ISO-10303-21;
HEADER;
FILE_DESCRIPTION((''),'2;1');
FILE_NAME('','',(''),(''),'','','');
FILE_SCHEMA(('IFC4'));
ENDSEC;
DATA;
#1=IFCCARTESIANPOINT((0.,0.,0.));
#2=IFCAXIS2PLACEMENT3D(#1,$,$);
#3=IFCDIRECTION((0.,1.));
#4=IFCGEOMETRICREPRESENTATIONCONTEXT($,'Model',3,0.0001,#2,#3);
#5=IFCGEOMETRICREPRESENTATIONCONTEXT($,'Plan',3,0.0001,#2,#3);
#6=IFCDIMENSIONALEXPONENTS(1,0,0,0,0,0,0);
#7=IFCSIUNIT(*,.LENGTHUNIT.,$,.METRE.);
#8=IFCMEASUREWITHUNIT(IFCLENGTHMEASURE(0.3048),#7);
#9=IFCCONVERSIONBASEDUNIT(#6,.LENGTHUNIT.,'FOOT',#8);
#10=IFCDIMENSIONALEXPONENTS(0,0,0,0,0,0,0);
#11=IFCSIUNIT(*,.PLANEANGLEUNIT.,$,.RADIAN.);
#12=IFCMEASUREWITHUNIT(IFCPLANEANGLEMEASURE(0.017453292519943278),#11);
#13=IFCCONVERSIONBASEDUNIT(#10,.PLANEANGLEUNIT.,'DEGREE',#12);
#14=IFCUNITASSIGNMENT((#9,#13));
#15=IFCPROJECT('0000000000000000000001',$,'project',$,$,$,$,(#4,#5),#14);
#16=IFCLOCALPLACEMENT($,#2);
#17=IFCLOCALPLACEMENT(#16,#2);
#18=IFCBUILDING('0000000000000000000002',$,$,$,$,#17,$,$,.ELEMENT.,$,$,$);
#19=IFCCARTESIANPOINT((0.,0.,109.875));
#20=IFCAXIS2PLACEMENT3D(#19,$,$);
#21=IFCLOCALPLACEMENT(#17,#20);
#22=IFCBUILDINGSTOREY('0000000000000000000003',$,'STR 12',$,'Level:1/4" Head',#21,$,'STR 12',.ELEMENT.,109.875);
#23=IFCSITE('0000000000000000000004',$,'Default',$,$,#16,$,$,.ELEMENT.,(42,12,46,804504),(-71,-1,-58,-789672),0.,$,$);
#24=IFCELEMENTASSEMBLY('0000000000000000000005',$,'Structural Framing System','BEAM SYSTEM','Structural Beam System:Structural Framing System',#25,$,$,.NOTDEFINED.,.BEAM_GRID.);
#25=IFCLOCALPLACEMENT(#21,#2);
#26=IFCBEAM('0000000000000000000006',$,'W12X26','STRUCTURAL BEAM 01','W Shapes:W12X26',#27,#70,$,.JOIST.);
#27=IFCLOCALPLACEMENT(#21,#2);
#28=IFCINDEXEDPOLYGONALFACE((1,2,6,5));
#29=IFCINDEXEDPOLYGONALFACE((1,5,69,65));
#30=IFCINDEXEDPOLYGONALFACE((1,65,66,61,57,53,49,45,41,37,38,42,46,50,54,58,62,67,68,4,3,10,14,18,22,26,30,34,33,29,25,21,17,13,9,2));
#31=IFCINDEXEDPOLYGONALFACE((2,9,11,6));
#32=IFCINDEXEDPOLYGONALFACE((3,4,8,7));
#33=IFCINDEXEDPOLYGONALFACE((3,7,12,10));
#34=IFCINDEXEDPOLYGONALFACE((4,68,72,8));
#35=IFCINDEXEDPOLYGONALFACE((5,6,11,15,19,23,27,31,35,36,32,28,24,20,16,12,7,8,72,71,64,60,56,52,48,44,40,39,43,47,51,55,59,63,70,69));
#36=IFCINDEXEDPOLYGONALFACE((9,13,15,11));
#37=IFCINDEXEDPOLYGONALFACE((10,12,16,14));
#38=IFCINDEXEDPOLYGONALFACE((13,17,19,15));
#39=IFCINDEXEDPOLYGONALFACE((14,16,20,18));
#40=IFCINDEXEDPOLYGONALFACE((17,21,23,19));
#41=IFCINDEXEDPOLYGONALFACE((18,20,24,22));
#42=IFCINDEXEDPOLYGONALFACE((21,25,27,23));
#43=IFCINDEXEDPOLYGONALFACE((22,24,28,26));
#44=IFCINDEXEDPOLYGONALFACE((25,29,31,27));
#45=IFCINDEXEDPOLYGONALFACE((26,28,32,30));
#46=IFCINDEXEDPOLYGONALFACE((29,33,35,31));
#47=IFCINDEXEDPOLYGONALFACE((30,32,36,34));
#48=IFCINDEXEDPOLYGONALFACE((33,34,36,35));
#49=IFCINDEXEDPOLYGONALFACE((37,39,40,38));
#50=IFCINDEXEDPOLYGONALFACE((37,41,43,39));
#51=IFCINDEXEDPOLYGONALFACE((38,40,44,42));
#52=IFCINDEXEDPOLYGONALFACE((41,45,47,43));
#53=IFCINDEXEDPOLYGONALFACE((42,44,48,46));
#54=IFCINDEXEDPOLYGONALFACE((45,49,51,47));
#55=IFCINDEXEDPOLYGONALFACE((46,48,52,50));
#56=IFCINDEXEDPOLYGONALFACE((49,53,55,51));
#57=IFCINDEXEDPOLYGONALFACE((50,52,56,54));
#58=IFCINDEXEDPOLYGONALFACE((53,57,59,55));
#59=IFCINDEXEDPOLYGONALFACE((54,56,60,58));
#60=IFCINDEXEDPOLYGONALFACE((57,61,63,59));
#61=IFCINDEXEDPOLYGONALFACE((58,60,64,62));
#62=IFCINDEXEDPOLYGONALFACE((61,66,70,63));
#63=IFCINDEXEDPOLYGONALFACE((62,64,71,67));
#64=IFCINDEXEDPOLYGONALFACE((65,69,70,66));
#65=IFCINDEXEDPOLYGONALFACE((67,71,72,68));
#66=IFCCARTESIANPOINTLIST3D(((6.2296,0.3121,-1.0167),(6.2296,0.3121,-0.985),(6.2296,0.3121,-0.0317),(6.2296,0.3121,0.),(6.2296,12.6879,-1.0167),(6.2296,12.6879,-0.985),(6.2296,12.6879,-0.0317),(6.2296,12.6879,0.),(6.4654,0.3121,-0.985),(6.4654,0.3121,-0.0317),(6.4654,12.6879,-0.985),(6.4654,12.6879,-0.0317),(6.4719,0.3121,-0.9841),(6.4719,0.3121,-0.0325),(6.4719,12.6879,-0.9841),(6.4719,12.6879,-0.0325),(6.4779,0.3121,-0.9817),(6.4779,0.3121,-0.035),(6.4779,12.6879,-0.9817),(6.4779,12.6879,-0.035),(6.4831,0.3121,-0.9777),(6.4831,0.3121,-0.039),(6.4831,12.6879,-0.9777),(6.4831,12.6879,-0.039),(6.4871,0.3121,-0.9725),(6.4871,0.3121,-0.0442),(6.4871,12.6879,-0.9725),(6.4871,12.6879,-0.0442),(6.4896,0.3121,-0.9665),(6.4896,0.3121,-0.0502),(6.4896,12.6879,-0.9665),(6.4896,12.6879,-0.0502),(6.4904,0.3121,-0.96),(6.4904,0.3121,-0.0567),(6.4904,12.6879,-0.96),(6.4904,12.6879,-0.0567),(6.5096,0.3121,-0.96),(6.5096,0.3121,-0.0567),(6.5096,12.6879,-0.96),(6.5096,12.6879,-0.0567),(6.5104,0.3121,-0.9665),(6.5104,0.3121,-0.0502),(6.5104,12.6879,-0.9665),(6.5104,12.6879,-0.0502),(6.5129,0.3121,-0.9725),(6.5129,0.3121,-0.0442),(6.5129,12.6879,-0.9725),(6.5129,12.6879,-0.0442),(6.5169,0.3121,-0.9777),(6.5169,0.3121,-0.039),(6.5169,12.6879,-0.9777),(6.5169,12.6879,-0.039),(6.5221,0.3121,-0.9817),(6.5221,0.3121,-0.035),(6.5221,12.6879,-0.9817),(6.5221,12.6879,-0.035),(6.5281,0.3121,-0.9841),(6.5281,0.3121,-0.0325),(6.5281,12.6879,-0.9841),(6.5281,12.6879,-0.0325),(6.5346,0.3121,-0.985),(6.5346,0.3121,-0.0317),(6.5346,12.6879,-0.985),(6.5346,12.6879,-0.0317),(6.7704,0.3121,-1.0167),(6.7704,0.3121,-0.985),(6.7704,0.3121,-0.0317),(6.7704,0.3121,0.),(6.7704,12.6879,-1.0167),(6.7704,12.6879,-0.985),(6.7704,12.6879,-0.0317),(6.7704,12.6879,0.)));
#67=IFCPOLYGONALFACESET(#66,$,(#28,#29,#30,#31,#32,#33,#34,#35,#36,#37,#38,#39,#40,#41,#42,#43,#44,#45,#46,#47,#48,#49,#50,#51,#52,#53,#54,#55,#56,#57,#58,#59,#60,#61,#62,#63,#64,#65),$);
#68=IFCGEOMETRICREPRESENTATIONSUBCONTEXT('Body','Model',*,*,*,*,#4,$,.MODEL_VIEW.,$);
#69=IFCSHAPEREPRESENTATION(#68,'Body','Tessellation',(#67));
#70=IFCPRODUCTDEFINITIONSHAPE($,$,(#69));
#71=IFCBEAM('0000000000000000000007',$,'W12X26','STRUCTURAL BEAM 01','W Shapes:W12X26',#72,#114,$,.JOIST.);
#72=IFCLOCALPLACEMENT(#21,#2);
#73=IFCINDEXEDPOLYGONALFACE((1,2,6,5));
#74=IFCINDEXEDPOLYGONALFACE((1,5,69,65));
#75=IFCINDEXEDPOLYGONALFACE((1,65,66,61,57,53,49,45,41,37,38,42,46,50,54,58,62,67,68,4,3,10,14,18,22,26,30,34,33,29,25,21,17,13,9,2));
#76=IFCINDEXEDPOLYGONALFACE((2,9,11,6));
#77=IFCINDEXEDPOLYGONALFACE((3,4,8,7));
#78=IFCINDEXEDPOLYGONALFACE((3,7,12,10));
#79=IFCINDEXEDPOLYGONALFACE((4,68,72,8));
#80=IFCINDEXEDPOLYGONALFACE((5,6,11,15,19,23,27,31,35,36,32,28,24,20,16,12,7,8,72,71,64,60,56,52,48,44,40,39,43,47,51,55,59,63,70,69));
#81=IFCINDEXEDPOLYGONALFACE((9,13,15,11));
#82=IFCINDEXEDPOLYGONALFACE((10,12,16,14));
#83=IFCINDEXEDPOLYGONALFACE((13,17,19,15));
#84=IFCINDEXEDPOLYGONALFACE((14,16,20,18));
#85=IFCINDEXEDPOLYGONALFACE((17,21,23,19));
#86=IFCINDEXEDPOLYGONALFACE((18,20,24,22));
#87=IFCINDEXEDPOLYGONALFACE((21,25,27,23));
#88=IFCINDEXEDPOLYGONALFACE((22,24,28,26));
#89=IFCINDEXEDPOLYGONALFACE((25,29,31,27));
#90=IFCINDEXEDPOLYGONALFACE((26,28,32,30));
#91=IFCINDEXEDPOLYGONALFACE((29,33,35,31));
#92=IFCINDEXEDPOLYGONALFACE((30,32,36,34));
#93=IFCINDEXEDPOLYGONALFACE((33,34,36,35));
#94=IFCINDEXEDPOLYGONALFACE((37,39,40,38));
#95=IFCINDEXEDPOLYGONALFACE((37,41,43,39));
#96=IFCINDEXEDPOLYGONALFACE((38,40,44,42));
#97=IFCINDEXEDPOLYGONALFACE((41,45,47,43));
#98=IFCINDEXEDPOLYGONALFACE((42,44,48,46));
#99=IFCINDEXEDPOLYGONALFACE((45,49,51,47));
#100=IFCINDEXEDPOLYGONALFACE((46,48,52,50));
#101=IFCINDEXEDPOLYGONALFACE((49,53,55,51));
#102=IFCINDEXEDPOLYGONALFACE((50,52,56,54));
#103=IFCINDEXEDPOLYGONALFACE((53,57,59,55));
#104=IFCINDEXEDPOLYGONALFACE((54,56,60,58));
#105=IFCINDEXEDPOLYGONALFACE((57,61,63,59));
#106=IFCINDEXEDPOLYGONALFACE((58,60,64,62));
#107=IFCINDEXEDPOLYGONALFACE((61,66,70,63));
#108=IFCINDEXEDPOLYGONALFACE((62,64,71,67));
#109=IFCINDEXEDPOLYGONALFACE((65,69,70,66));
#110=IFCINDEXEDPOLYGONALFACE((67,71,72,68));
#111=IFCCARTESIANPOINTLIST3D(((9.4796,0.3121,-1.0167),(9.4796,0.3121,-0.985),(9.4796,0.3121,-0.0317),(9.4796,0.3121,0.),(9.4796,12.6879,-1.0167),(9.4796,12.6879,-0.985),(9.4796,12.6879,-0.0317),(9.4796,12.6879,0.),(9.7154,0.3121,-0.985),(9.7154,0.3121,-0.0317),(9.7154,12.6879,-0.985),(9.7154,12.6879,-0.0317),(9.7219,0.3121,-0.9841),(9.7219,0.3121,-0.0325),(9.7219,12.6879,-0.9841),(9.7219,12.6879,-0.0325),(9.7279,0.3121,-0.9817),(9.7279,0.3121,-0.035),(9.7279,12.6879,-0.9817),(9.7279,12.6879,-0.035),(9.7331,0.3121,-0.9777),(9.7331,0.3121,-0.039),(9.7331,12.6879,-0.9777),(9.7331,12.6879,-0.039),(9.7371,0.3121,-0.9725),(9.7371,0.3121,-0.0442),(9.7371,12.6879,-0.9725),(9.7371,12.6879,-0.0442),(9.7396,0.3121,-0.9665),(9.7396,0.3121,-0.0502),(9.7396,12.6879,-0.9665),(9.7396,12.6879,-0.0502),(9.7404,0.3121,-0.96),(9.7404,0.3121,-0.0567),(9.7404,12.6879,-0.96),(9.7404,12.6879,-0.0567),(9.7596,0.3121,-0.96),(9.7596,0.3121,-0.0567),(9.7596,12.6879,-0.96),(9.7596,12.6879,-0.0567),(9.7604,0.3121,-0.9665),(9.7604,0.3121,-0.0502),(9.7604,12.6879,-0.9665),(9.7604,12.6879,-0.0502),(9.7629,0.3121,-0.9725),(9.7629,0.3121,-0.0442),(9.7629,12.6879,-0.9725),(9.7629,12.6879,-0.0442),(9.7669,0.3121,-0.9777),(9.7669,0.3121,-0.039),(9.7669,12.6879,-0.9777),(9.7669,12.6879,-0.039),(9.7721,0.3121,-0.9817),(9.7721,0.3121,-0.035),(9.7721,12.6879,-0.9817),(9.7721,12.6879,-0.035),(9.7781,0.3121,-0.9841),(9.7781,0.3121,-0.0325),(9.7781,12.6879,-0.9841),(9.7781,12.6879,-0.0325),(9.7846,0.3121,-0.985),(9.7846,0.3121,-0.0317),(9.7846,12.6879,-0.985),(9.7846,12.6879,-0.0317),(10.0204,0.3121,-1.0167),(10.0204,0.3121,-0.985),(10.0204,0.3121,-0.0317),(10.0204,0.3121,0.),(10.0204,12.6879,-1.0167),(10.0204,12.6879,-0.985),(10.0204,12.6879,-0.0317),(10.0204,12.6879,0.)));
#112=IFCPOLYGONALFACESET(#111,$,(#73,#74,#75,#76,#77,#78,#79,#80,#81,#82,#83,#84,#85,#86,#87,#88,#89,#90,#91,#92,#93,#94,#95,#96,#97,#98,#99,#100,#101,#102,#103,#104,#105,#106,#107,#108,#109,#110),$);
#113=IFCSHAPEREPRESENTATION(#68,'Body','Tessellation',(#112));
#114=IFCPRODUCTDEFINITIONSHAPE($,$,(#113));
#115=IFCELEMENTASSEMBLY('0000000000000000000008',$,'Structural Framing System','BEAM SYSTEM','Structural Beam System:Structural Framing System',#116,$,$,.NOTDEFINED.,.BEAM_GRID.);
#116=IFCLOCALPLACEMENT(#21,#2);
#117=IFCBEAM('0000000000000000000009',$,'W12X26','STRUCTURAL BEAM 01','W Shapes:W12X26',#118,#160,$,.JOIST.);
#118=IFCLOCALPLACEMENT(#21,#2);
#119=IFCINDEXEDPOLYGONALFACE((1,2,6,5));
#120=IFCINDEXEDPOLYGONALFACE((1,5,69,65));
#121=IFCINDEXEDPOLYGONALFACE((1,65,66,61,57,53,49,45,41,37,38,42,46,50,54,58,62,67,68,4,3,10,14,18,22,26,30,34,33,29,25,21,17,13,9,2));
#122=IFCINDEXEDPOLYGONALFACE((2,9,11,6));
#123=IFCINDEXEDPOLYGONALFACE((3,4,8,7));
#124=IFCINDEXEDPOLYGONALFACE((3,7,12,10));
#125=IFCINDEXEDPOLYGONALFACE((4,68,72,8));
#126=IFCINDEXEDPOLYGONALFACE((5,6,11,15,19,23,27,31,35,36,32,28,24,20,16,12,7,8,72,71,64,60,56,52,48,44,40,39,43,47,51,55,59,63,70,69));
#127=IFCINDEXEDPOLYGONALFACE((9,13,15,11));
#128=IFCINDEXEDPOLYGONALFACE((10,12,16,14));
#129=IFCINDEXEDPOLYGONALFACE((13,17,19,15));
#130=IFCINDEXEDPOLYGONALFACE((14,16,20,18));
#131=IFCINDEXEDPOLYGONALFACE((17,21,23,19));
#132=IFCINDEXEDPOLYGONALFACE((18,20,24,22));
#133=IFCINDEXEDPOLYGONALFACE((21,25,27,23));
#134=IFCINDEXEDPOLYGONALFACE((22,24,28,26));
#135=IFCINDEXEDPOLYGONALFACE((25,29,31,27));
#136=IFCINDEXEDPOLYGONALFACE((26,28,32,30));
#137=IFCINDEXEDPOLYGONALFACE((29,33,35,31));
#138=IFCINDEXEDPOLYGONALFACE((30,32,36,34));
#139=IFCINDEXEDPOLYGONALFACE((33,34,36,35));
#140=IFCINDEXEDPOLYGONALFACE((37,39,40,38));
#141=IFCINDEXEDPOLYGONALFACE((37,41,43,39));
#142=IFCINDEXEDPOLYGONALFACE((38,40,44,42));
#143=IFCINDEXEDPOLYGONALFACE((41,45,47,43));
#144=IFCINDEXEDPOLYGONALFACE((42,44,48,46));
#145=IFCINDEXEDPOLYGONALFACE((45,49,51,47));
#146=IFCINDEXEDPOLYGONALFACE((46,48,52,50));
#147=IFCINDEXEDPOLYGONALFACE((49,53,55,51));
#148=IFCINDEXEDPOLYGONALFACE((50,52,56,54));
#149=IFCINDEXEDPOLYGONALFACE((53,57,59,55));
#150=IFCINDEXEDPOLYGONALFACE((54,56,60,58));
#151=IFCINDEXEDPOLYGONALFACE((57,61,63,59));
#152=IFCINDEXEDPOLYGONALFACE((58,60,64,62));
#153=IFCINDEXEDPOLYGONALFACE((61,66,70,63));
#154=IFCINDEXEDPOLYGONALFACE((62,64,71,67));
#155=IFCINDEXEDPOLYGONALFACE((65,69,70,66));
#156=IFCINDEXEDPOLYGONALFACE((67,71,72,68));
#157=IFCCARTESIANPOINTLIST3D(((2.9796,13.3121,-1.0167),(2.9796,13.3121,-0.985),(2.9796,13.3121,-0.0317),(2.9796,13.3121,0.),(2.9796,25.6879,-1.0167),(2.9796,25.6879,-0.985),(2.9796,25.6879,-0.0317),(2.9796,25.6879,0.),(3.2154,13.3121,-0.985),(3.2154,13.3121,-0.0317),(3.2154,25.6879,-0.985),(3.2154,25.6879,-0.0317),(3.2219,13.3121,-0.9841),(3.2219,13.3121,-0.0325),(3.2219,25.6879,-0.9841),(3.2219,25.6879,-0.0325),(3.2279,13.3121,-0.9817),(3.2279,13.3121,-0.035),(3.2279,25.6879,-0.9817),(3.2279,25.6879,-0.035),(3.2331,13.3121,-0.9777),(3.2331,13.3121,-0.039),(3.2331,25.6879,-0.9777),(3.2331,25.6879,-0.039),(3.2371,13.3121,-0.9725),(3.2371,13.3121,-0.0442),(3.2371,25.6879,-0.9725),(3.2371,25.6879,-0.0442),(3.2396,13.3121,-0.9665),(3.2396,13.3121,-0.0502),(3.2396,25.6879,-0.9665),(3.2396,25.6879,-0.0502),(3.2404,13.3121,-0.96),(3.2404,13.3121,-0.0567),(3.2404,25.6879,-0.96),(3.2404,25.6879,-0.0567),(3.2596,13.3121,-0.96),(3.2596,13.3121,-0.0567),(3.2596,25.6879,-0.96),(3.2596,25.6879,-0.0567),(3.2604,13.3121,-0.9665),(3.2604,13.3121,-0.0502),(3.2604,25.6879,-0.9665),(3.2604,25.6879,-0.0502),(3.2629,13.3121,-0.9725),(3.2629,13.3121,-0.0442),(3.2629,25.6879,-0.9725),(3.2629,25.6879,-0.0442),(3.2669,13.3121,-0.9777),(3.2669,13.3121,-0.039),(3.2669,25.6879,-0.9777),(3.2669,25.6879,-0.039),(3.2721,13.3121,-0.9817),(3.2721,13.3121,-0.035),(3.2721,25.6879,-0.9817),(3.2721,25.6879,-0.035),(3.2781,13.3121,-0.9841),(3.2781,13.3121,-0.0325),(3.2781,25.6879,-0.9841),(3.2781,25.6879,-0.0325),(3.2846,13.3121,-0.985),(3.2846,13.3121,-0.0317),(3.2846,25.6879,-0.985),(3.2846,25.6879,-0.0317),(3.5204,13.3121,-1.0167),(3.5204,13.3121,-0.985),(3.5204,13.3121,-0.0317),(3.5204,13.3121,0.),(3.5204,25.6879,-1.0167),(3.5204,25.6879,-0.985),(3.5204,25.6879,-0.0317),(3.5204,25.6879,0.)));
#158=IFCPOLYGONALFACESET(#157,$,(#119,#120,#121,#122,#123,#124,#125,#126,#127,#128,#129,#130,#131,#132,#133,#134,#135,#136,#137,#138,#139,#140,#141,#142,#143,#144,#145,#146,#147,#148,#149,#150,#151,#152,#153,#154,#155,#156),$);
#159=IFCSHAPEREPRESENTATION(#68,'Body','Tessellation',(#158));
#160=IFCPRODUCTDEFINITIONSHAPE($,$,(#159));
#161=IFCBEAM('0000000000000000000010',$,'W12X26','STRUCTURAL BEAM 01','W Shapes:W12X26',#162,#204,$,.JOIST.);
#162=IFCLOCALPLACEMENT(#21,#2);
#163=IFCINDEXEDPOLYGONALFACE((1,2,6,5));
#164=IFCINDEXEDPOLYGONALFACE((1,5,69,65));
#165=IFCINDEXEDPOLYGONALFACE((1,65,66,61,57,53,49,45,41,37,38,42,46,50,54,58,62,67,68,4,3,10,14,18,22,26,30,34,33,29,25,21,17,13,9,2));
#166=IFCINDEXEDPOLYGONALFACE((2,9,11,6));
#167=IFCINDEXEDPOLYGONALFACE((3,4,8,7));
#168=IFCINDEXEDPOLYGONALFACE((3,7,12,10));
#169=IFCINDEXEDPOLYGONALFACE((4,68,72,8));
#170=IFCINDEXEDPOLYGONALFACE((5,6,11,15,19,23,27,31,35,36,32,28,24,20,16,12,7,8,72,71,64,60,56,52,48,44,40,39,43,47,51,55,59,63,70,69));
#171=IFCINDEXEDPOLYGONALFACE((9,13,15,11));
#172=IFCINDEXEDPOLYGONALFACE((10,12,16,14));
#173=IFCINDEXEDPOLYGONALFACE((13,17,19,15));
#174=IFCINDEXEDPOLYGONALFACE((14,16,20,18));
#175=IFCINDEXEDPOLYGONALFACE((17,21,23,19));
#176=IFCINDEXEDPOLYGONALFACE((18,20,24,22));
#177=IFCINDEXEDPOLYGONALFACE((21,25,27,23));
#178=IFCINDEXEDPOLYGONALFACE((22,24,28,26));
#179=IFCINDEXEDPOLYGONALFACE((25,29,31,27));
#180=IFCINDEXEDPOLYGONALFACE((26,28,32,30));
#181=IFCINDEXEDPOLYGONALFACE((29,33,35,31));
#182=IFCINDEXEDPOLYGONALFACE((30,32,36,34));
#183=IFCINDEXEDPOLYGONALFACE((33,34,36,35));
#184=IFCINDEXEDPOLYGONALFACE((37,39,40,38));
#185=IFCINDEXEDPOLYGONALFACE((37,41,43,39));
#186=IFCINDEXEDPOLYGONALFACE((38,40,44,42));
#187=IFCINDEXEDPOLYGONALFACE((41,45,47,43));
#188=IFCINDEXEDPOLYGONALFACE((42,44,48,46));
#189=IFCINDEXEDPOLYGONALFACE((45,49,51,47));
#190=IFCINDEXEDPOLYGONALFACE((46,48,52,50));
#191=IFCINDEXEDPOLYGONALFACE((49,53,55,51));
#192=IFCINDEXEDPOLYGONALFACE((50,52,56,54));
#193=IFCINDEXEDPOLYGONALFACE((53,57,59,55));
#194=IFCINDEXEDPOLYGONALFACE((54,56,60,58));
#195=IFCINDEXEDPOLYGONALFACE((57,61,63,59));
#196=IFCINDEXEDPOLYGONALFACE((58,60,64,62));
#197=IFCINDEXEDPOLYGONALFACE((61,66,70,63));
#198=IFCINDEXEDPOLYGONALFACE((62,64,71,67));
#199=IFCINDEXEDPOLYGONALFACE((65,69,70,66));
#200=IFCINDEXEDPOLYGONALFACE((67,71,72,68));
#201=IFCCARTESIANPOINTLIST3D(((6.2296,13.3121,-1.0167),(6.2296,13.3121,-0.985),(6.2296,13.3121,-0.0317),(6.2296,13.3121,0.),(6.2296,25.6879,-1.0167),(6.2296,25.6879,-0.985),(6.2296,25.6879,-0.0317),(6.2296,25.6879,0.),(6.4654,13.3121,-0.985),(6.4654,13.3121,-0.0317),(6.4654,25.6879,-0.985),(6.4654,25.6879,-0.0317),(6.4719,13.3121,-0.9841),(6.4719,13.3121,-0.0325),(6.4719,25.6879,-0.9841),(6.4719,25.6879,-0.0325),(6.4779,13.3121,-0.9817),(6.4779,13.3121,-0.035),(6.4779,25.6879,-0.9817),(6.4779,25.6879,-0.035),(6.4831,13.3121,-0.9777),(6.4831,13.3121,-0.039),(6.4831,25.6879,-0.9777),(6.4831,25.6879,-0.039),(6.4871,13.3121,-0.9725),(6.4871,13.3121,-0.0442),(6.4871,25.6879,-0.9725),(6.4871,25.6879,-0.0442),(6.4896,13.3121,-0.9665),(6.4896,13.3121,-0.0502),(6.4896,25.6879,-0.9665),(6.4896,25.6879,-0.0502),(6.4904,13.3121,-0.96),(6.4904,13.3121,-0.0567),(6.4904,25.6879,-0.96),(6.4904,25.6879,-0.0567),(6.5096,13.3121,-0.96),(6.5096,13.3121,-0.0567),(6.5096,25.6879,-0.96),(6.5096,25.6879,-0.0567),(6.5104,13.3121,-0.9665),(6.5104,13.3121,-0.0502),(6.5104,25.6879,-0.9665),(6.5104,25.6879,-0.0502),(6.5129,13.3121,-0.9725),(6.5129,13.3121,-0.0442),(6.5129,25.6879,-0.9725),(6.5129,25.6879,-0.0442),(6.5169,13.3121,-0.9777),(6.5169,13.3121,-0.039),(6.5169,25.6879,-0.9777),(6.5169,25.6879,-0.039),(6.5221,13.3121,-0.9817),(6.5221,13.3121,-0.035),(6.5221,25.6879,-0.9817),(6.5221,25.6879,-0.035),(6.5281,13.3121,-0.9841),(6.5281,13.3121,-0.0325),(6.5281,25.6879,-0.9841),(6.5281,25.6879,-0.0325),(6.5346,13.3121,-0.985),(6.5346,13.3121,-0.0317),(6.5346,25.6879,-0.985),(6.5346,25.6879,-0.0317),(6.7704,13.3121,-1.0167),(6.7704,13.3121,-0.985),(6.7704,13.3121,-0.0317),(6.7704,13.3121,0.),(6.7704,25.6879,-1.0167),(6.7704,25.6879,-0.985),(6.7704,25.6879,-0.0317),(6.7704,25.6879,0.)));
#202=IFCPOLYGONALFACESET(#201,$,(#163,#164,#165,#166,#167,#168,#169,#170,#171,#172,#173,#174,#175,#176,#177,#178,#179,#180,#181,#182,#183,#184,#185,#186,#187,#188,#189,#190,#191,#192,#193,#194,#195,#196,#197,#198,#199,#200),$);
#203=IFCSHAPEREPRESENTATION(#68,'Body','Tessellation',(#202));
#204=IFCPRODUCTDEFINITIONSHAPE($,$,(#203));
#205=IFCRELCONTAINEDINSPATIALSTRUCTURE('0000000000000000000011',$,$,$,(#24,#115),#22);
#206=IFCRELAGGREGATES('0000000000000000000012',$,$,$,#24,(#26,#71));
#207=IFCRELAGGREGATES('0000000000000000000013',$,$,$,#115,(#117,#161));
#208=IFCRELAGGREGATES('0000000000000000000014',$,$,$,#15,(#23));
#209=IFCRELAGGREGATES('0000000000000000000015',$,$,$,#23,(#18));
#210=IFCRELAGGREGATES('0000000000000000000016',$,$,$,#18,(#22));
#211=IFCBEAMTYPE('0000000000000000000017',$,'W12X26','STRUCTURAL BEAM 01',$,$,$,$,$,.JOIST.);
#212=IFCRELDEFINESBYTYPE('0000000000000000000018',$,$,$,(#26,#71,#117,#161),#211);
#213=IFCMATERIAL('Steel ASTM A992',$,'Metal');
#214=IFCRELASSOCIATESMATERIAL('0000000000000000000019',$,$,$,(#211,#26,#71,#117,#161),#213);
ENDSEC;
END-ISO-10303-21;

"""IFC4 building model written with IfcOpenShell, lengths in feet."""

from ifc_helpers import new_model, entity, si_unit, converted_unit, direction, frame, origin, place, context, subcontext, project, spatial, line, arc, indexed_curve, outline, extrude, source, transform, mapped, material, type_object, type_shapes, element, aggregate, save


model = new_model("IFC4")

# Units and contexts
model_context = context("Model", 3, precision=0.0001, world=origin(), true_north=direction((0.0, 1.0)))
plan_context = context("Plan", 3, precision=0.0001, world=origin(), true_north=direction((0.0, 1.0)))
body_context = subcontext(model_context, "Body", "Model", "MODEL_VIEW")
ifc_project = project(units=[converted_unit("LENGTHUNIT", "FOOT", entity("IfcLengthMeasure", 0.3048), si_unit("LENGTHUNIT", "METRE"), dimensions=[1, 0, 0, 0, 0, 0, 0]), converted_unit("PLANEANGLEUNIT", "DEGREE", entity("IfcPlaneAngleMeasure", 0.017453292519943278), si_unit("PLANEANGLEUNIT", "RADIAN"), dimensions=[0, 0, 0, 0, 0, 0, 0])], contexts=[model_context, plan_context])

# Site, building, storey
site_placement = place(None, origin())
site = spatial("IfcSite", under=ifc_project, at=site_placement, Name="Default", CompositionType="ELEMENT", RefLatitude=(42, 12, 46, 804504), RefLongitude=(-71, -1, -58, -789672), RefElevation=0.0)
building_placement = place(site_placement, origin())
building = spatial("IfcBuilding", under=site, at=building_placement, CompositionType="ELEMENT")
storey_placement = place(building_placement, frame((0.0, 0.0, 109.875)))
storey = spatial("IfcBuildingStorey", under=building, at=storey_placement, Name="STR 12", ObjectType="Level:1/4\" Head", LongName="STR 12", CompositionType="ELEMENT", Elevation=109.875)

# Element assemblies, beams
assembly_1_placement = place(storey_placement, origin())
assembly_1 = element("IfcElementAssembly", 1, at=assembly_1_placement, inside=storey, Name="Structural Framing System", Description="BEAM SYSTEM", ObjectType="Structural Beam System:Structural Framing System", AssemblyPlace="NOTDEFINED", PredefinedType="BEAM_GRID")
ifc_material = material(Name="Steel ASTM A992", Category="Metal")
beam_type = type_object("IfcBeamType", Name="W12X26", Description="STRUCTURAL BEAM 01", PredefinedType="JOIST", material=ifc_material)
shared_shape = source(origin(), body_context, "Body", "SweptSolid", [
    extrude(outline(indexed_curve([(-0.2704, -0.4767), (-0.2704, -0.5083), (0.2704, -0.5083), (0.2704, -0.4767), (0.0346, -0.4767), (0.0169, -0.4693), (0.0096, -0.4517), (0.0096, 0.4517), (0.0169, 0.4693), (0.0346, 0.4767), (0.2704, 0.4767), (0.2704, 0.5083), (-0.2704, 0.5083), (-0.2704, 0.4767), (-0.0346, 0.4767), (-0.0169, 0.4693), (-0.0096, 0.4517), (-0.0096, -0.4517), (-0.0169, -0.4693), (-0.0346, -0.4767)], segments=[line(1, 2, 3, 4, 5), arc(5, 6, 7), line(7, 8), arc(8, 9, 10), line(10, 11, 12, 13, 14, 15), arc(15, 16, 17), line(17, 18), arc(18, 19, 20), line(20, 1)], self_intersect=False)), frame((-6.1879, 0.0, 0.0), z_axis=(-1.0, 0.0, 0.0), x_axis=(0.0, -1.0, 0.0)), (0.0, 0.0, -1.0), 12.3758),
])
type_shapes(beam_type, [shared_shape])
beam_1_placement = place(assembly_1_placement, frame((6.5, 6.5, -0.5083), z_axis=(0.0, 0.0, 1.0), x_axis=(0.0, 1.0, 0.0)))
beam_1 = element("IfcBeam", 2, at=beam_1_placement, type_object=beam_type, material=ifc_material, Name="W12X26", Description="STRUCTURAL BEAM 01", ObjectType="W Shapes:W12X26", PredefinedType="JOIST", context=body_context, shape_type="MappedRepresentation", body=[
    mapped(shared_shape, transform((0.0, 0.0, 0.0), scale=1.0)),
])
beam_2_placement = place(assembly_1_placement, frame((9.75, 6.5, -0.5083), z_axis=(0.0, 0.0, 1.0), x_axis=(0.0, 1.0, 0.0)))
beam_2 = element("IfcBeam", 3, at=beam_2_placement, type_object=beam_type, material=ifc_material, Name="W12X26", Description="STRUCTURAL BEAM 01", ObjectType="W Shapes:W12X26", PredefinedType="JOIST", context=body_context, shape_type="MappedRepresentation", body=[
    mapped(shared_shape, transform((0.0, 0.0, 0.0), scale=1.0)),
])
aggregate(assembly_1, [beam_1, beam_2])
assembly_2_placement = place(storey_placement, origin())
assembly_2 = element("IfcElementAssembly", 4, at=assembly_2_placement, inside=storey, Name="Structural Framing System", Description="BEAM SYSTEM", ObjectType="Structural Beam System:Structural Framing System", AssemblyPlace="NOTDEFINED", PredefinedType="BEAM_GRID")
beam_3_placement = place(assembly_2_placement, frame((3.25, 19.5, -0.5083), z_axis=(0.0, 0.0, 1.0), x_axis=(0.0, 1.0, 0.0)))
beam_3 = element("IfcBeam", 5, at=beam_3_placement, type_object=beam_type, material=ifc_material, Name="W12X26", Description="STRUCTURAL BEAM 01", ObjectType="W Shapes:W12X26", PredefinedType="JOIST", context=body_context, shape_type="MappedRepresentation", body=[
    mapped(shared_shape, transform((0.0, 0.0, 0.0), scale=1.0)),
])
beam_4_placement = place(assembly_2_placement, frame((6.5, 19.5, -0.5083), z_axis=(0.0, 0.0, 1.0), x_axis=(0.0, 1.0, 0.0)))
beam_4 = element("IfcBeam", 6, at=beam_4_placement, type_object=beam_type, material=ifc_material, Name="W12X26", Description="STRUCTURAL BEAM 01", ObjectType="W Shapes:W12X26", PredefinedType="JOIST", context=body_context, shape_type="MappedRepresentation", body=[
    mapped(shared_shape, transform((0.0, 0.0, 0.0), scale=1.0)),
])
aggregate(assembly_2, [beam_3, beam_4])

save(model, "model.ifc")
